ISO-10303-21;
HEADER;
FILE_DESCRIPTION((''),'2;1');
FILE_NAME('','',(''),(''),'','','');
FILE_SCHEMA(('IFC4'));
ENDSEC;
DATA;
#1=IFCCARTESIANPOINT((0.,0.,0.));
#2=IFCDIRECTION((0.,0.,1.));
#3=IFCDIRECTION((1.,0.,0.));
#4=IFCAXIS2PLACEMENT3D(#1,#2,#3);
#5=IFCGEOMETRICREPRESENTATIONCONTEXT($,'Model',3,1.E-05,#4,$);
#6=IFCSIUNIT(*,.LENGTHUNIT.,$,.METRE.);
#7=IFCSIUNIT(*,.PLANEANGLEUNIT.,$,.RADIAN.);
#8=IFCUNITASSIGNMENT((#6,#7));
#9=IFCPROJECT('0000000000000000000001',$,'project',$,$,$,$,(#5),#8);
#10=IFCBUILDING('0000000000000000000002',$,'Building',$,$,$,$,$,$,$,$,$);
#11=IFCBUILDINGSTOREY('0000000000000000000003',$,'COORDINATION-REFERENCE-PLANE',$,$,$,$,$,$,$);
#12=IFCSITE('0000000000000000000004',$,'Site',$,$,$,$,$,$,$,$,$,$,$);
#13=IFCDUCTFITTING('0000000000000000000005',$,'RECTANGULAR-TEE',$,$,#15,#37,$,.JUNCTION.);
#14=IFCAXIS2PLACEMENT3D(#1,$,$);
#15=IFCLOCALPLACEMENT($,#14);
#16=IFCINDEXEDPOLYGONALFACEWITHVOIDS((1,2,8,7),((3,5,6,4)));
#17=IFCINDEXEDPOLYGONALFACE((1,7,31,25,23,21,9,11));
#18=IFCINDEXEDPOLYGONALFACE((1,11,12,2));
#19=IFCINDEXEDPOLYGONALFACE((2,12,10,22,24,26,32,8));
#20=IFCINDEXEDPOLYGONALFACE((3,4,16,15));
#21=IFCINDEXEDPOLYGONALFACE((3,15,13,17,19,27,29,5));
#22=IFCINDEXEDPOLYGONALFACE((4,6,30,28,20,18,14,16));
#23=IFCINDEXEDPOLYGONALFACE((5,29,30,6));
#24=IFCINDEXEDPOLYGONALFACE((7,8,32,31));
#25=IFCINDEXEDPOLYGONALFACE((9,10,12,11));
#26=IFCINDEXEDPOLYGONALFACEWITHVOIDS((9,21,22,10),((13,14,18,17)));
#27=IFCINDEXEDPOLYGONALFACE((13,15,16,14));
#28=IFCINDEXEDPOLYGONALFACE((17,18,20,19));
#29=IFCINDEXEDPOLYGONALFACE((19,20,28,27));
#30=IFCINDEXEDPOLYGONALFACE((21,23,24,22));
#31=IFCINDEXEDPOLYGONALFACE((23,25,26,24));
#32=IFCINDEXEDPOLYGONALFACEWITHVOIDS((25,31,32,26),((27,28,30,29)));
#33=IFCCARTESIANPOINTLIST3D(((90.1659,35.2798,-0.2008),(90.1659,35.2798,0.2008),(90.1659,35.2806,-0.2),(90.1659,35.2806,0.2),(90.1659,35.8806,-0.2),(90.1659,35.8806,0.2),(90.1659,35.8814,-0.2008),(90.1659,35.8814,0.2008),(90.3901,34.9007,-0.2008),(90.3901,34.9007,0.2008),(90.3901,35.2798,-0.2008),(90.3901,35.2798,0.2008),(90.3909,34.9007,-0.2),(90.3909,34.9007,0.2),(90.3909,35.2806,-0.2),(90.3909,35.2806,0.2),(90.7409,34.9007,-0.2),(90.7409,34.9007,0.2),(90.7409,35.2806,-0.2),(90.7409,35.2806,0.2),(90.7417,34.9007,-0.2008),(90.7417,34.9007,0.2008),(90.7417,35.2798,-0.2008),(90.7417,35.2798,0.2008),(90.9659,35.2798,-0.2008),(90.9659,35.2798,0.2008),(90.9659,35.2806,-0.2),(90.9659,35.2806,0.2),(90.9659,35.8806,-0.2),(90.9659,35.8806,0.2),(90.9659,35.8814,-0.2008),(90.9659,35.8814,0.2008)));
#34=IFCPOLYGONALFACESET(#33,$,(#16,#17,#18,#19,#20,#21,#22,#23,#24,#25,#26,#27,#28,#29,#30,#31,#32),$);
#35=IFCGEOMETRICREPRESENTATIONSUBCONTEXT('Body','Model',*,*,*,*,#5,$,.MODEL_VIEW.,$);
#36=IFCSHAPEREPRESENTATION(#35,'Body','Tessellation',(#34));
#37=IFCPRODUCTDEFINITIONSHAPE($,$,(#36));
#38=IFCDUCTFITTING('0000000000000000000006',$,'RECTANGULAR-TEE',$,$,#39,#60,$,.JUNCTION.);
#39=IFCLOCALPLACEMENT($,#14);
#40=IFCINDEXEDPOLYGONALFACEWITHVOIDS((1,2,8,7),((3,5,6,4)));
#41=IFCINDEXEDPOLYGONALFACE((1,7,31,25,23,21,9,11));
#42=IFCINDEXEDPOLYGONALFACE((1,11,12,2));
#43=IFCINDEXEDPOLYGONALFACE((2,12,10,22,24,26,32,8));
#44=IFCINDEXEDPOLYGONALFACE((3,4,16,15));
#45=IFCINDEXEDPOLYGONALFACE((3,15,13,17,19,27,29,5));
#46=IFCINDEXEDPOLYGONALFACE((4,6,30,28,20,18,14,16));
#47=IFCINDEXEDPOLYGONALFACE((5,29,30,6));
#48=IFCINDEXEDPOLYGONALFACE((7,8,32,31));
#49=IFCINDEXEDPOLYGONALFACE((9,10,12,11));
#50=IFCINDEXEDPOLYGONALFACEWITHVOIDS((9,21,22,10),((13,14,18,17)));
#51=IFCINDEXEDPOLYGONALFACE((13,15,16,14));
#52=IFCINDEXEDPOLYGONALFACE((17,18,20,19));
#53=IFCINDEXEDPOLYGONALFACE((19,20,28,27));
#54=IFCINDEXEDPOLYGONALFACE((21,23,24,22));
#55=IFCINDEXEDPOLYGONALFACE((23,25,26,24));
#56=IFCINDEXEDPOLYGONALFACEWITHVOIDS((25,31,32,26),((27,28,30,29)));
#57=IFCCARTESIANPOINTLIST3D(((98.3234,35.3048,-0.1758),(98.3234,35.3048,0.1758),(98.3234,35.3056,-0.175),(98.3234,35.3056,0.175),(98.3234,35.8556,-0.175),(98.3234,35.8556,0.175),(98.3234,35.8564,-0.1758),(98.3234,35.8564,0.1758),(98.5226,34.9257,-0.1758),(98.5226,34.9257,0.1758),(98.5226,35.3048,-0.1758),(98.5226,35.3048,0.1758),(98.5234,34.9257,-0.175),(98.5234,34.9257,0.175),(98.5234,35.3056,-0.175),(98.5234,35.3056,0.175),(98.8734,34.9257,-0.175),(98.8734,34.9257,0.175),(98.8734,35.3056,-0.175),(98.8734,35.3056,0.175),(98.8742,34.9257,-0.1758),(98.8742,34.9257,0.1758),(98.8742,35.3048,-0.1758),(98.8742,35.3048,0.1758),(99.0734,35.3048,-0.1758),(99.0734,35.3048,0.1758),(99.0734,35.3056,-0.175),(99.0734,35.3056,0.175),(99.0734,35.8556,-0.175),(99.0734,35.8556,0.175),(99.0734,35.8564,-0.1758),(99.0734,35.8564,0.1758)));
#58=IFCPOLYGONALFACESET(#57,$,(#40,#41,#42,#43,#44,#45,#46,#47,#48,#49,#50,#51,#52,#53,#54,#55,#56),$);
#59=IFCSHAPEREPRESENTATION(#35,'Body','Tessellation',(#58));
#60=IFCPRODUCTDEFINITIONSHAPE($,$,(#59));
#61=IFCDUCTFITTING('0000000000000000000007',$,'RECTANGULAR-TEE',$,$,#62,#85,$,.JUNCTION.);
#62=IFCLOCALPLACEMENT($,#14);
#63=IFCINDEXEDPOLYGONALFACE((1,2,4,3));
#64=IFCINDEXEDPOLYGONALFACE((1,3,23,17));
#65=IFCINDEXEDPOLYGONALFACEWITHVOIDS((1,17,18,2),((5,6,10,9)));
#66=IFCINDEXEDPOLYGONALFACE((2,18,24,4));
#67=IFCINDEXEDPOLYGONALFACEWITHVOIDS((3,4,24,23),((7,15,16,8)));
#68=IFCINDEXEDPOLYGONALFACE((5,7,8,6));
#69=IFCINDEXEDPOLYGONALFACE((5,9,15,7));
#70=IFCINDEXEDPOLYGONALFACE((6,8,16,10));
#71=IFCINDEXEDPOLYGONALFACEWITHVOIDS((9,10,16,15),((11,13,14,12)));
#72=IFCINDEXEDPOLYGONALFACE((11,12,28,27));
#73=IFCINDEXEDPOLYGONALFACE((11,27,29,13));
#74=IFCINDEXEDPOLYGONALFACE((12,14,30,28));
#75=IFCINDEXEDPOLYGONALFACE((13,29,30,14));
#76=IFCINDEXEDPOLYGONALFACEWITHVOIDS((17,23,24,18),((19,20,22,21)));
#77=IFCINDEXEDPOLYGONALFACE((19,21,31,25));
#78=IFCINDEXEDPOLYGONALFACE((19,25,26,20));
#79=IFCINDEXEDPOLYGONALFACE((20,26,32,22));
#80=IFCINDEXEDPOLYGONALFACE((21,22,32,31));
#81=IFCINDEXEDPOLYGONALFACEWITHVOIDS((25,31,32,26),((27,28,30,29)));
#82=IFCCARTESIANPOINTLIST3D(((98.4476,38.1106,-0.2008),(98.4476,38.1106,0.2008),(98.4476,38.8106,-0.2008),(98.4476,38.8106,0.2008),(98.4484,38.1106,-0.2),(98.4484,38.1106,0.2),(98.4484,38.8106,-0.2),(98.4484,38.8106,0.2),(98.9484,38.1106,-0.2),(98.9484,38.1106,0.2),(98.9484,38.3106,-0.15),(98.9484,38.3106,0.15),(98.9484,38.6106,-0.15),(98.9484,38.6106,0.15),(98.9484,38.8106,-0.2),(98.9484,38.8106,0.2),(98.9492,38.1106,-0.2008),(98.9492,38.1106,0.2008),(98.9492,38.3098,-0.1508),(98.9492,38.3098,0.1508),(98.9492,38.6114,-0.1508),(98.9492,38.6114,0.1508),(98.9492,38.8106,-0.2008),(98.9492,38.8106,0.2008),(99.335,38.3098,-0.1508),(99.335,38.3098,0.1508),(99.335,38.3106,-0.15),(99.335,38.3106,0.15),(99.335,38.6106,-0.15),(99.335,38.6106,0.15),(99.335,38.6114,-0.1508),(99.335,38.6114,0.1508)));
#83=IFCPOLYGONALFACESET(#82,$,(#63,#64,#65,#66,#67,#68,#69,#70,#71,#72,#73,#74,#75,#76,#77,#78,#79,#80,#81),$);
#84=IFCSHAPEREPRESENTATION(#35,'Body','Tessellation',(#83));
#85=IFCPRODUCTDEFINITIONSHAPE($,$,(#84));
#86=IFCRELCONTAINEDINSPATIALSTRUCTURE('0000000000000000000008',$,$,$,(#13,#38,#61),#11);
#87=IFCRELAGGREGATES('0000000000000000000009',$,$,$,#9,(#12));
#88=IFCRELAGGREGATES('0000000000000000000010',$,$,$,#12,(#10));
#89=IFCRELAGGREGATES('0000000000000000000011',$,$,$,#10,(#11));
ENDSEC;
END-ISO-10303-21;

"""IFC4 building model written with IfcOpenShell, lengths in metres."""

from ifc_helpers import new_model, si_unit, frame, origin_with_axes, place, context, subcontext, project, spatial, rectangle, extrude, boolean, element, save


model = new_model("IFC4")

# Units and contexts
model_context = context("Model", 3, precision=1e-05, world=origin_with_axes())
body_context = subcontext(model_context, "Body", "Model", "MODEL_VIEW")
ifc_project = project(units=[si_unit("LENGTHUNIT", "METRE"), si_unit("PLANEANGLEUNIT", "RADIAN")], contexts=[model_context])

# Site, building, storey
site = spatial("IfcSite", under=ifc_project, Name="Site")
building = spatial("IfcBuilding", under=site, Name="Building")
storey = spatial("IfcBuildingStorey", under=building, Name="COORDINATION-REFERENCE-PLANE")

# Duct fittings
duct_fitting_1_placement = place(None, frame((90.5659, 35.5806, 0.0), z_axis=(1.0, 0.0, 0.0), x_axis=(0.0, -1.0, 0.0)))
solid_1 = boolean("UNION", extrude(rectangle(XDim=0.6, YDim=0.4), frame((0.0, 0.0, -0.4), z_axis=(0.0, 0.0, 1.0), x_axis=(1.0, 0.0, 0.0)), (0.0, 0.0, 1.0), 0.8), extrude(rectangle(XDim=0.35, YDim=0.4), frame((0.0, 0.0, 0.0), z_axis=(1.0, 0.0, 0.0), x_axis=(0.0, 0.0, -1.0)), (0.0, 0.0, 1.0), 0.6799))
element("IfcDuctFitting", 1, at=duct_fitting_1_placement, inside=storey, Name="RECTANGULAR-TEE", PredefinedType="JUNCTION", context=body_context, shape_type="CSG", body=[
    boolean("DIFFERENCE", boolean("UNION", extrude(rectangle(XDim=0.6016, YDim=0.4016), frame((0.0, 0.0, -0.4), z_axis=(0.0, 0.0, 1.0), x_axis=(1.0, 0.0, 0.0)), (0.0, 0.0, 1.0), 0.8), extrude(rectangle(XDim=0.3516, YDim=0.4016), frame((0.0, 0.0, 0.0), z_axis=(1.0, 0.0, 0.0), x_axis=(0.0, 0.0, -1.0)), (0.0, 0.0, 1.0), 0.6799)), solid_1),
])
duct_fitting_2_placement = place(None, frame((98.6984, 35.5806, 0.0), z_axis=(1.0, 0.0, 0.0), x_axis=(0.0, -1.0, 0.0)))
solid_2 = boolean("UNION", extrude(rectangle(XDim=0.55, YDim=0.35), frame((0.0, 0.0, -0.375), z_axis=(0.0, 0.0, 1.0), x_axis=(1.0, 0.0, 0.0)), (0.0, 0.0, 1.0), 0.75), extrude(rectangle(XDim=0.35, YDim=0.35), frame((0.0, 0.0, 0.0), z_axis=(1.0, 0.0, 0.0), x_axis=(0.0, 0.0, -1.0)), (0.0, 0.0, 1.0), 0.6549))
element("IfcDuctFitting", 2, at=duct_fitting_2_placement, inside=storey, Name="RECTANGULAR-TEE", PredefinedType="JUNCTION", context=body_context, shape_type="CSG", body=[
    boolean("DIFFERENCE", boolean("UNION", extrude(rectangle(XDim=0.5516, YDim=0.3516), frame((0.0, 0.0, -0.375), z_axis=(0.0, 0.0, 1.0), x_axis=(1.0, 0.0, 0.0)), (0.0, 0.0, 1.0), 0.75), extrude(rectangle(XDim=0.3516, YDim=0.3516), frame((0.0, 0.0, 0.0), z_axis=(1.0, 0.0, 0.0), x_axis=(0.0, 0.0, -1.0)), (0.0, 0.0, 1.0), 0.6549)), solid_2),
])
duct_fitting_3_placement = place(None, frame((98.6984, 38.4606, 0.0), z_axis=(0.0, 1.0, 0.0), x_axis=(1.0, 0.0, 0.0)))
solid_3 = boolean("UNION", extrude(rectangle(XDim=0.5, YDim=0.4), frame((0.0, 0.0, -0.35), z_axis=(0.0, 0.0, 1.0), x_axis=(1.0, 0.0, 0.0)), (0.0, 0.0, 1.0), 0.7), extrude(rectangle(XDim=0.3, YDim=0.3), frame((0.0, 0.0, 0.0), z_axis=(1.0, 0.0, 0.0), x_axis=(0.0, 0.0, -1.0)), (0.0, 0.0, 1.0), 0.6366))
element("IfcDuctFitting", 3, at=duct_fitting_3_placement, inside=storey, Name="RECTANGULAR-TEE", PredefinedType="JUNCTION", context=body_context, shape_type="CSG", body=[
    boolean("DIFFERENCE", boolean("UNION", extrude(rectangle(XDim=0.5016, YDim=0.4016), frame((0.0, 0.0, -0.35), z_axis=(0.0, 0.0, 1.0), x_axis=(1.0, 0.0, 0.0)), (0.0, 0.0, 1.0), 0.7), extrude(rectangle(XDim=0.3016, YDim=0.3016), frame((0.0, 0.0, 0.0), z_axis=(1.0, 0.0, 0.0), x_axis=(0.0, 0.0, -1.0)), (0.0, 0.0, 1.0), 0.6366)), solid_3),
])

save(model, "model.ifc")
